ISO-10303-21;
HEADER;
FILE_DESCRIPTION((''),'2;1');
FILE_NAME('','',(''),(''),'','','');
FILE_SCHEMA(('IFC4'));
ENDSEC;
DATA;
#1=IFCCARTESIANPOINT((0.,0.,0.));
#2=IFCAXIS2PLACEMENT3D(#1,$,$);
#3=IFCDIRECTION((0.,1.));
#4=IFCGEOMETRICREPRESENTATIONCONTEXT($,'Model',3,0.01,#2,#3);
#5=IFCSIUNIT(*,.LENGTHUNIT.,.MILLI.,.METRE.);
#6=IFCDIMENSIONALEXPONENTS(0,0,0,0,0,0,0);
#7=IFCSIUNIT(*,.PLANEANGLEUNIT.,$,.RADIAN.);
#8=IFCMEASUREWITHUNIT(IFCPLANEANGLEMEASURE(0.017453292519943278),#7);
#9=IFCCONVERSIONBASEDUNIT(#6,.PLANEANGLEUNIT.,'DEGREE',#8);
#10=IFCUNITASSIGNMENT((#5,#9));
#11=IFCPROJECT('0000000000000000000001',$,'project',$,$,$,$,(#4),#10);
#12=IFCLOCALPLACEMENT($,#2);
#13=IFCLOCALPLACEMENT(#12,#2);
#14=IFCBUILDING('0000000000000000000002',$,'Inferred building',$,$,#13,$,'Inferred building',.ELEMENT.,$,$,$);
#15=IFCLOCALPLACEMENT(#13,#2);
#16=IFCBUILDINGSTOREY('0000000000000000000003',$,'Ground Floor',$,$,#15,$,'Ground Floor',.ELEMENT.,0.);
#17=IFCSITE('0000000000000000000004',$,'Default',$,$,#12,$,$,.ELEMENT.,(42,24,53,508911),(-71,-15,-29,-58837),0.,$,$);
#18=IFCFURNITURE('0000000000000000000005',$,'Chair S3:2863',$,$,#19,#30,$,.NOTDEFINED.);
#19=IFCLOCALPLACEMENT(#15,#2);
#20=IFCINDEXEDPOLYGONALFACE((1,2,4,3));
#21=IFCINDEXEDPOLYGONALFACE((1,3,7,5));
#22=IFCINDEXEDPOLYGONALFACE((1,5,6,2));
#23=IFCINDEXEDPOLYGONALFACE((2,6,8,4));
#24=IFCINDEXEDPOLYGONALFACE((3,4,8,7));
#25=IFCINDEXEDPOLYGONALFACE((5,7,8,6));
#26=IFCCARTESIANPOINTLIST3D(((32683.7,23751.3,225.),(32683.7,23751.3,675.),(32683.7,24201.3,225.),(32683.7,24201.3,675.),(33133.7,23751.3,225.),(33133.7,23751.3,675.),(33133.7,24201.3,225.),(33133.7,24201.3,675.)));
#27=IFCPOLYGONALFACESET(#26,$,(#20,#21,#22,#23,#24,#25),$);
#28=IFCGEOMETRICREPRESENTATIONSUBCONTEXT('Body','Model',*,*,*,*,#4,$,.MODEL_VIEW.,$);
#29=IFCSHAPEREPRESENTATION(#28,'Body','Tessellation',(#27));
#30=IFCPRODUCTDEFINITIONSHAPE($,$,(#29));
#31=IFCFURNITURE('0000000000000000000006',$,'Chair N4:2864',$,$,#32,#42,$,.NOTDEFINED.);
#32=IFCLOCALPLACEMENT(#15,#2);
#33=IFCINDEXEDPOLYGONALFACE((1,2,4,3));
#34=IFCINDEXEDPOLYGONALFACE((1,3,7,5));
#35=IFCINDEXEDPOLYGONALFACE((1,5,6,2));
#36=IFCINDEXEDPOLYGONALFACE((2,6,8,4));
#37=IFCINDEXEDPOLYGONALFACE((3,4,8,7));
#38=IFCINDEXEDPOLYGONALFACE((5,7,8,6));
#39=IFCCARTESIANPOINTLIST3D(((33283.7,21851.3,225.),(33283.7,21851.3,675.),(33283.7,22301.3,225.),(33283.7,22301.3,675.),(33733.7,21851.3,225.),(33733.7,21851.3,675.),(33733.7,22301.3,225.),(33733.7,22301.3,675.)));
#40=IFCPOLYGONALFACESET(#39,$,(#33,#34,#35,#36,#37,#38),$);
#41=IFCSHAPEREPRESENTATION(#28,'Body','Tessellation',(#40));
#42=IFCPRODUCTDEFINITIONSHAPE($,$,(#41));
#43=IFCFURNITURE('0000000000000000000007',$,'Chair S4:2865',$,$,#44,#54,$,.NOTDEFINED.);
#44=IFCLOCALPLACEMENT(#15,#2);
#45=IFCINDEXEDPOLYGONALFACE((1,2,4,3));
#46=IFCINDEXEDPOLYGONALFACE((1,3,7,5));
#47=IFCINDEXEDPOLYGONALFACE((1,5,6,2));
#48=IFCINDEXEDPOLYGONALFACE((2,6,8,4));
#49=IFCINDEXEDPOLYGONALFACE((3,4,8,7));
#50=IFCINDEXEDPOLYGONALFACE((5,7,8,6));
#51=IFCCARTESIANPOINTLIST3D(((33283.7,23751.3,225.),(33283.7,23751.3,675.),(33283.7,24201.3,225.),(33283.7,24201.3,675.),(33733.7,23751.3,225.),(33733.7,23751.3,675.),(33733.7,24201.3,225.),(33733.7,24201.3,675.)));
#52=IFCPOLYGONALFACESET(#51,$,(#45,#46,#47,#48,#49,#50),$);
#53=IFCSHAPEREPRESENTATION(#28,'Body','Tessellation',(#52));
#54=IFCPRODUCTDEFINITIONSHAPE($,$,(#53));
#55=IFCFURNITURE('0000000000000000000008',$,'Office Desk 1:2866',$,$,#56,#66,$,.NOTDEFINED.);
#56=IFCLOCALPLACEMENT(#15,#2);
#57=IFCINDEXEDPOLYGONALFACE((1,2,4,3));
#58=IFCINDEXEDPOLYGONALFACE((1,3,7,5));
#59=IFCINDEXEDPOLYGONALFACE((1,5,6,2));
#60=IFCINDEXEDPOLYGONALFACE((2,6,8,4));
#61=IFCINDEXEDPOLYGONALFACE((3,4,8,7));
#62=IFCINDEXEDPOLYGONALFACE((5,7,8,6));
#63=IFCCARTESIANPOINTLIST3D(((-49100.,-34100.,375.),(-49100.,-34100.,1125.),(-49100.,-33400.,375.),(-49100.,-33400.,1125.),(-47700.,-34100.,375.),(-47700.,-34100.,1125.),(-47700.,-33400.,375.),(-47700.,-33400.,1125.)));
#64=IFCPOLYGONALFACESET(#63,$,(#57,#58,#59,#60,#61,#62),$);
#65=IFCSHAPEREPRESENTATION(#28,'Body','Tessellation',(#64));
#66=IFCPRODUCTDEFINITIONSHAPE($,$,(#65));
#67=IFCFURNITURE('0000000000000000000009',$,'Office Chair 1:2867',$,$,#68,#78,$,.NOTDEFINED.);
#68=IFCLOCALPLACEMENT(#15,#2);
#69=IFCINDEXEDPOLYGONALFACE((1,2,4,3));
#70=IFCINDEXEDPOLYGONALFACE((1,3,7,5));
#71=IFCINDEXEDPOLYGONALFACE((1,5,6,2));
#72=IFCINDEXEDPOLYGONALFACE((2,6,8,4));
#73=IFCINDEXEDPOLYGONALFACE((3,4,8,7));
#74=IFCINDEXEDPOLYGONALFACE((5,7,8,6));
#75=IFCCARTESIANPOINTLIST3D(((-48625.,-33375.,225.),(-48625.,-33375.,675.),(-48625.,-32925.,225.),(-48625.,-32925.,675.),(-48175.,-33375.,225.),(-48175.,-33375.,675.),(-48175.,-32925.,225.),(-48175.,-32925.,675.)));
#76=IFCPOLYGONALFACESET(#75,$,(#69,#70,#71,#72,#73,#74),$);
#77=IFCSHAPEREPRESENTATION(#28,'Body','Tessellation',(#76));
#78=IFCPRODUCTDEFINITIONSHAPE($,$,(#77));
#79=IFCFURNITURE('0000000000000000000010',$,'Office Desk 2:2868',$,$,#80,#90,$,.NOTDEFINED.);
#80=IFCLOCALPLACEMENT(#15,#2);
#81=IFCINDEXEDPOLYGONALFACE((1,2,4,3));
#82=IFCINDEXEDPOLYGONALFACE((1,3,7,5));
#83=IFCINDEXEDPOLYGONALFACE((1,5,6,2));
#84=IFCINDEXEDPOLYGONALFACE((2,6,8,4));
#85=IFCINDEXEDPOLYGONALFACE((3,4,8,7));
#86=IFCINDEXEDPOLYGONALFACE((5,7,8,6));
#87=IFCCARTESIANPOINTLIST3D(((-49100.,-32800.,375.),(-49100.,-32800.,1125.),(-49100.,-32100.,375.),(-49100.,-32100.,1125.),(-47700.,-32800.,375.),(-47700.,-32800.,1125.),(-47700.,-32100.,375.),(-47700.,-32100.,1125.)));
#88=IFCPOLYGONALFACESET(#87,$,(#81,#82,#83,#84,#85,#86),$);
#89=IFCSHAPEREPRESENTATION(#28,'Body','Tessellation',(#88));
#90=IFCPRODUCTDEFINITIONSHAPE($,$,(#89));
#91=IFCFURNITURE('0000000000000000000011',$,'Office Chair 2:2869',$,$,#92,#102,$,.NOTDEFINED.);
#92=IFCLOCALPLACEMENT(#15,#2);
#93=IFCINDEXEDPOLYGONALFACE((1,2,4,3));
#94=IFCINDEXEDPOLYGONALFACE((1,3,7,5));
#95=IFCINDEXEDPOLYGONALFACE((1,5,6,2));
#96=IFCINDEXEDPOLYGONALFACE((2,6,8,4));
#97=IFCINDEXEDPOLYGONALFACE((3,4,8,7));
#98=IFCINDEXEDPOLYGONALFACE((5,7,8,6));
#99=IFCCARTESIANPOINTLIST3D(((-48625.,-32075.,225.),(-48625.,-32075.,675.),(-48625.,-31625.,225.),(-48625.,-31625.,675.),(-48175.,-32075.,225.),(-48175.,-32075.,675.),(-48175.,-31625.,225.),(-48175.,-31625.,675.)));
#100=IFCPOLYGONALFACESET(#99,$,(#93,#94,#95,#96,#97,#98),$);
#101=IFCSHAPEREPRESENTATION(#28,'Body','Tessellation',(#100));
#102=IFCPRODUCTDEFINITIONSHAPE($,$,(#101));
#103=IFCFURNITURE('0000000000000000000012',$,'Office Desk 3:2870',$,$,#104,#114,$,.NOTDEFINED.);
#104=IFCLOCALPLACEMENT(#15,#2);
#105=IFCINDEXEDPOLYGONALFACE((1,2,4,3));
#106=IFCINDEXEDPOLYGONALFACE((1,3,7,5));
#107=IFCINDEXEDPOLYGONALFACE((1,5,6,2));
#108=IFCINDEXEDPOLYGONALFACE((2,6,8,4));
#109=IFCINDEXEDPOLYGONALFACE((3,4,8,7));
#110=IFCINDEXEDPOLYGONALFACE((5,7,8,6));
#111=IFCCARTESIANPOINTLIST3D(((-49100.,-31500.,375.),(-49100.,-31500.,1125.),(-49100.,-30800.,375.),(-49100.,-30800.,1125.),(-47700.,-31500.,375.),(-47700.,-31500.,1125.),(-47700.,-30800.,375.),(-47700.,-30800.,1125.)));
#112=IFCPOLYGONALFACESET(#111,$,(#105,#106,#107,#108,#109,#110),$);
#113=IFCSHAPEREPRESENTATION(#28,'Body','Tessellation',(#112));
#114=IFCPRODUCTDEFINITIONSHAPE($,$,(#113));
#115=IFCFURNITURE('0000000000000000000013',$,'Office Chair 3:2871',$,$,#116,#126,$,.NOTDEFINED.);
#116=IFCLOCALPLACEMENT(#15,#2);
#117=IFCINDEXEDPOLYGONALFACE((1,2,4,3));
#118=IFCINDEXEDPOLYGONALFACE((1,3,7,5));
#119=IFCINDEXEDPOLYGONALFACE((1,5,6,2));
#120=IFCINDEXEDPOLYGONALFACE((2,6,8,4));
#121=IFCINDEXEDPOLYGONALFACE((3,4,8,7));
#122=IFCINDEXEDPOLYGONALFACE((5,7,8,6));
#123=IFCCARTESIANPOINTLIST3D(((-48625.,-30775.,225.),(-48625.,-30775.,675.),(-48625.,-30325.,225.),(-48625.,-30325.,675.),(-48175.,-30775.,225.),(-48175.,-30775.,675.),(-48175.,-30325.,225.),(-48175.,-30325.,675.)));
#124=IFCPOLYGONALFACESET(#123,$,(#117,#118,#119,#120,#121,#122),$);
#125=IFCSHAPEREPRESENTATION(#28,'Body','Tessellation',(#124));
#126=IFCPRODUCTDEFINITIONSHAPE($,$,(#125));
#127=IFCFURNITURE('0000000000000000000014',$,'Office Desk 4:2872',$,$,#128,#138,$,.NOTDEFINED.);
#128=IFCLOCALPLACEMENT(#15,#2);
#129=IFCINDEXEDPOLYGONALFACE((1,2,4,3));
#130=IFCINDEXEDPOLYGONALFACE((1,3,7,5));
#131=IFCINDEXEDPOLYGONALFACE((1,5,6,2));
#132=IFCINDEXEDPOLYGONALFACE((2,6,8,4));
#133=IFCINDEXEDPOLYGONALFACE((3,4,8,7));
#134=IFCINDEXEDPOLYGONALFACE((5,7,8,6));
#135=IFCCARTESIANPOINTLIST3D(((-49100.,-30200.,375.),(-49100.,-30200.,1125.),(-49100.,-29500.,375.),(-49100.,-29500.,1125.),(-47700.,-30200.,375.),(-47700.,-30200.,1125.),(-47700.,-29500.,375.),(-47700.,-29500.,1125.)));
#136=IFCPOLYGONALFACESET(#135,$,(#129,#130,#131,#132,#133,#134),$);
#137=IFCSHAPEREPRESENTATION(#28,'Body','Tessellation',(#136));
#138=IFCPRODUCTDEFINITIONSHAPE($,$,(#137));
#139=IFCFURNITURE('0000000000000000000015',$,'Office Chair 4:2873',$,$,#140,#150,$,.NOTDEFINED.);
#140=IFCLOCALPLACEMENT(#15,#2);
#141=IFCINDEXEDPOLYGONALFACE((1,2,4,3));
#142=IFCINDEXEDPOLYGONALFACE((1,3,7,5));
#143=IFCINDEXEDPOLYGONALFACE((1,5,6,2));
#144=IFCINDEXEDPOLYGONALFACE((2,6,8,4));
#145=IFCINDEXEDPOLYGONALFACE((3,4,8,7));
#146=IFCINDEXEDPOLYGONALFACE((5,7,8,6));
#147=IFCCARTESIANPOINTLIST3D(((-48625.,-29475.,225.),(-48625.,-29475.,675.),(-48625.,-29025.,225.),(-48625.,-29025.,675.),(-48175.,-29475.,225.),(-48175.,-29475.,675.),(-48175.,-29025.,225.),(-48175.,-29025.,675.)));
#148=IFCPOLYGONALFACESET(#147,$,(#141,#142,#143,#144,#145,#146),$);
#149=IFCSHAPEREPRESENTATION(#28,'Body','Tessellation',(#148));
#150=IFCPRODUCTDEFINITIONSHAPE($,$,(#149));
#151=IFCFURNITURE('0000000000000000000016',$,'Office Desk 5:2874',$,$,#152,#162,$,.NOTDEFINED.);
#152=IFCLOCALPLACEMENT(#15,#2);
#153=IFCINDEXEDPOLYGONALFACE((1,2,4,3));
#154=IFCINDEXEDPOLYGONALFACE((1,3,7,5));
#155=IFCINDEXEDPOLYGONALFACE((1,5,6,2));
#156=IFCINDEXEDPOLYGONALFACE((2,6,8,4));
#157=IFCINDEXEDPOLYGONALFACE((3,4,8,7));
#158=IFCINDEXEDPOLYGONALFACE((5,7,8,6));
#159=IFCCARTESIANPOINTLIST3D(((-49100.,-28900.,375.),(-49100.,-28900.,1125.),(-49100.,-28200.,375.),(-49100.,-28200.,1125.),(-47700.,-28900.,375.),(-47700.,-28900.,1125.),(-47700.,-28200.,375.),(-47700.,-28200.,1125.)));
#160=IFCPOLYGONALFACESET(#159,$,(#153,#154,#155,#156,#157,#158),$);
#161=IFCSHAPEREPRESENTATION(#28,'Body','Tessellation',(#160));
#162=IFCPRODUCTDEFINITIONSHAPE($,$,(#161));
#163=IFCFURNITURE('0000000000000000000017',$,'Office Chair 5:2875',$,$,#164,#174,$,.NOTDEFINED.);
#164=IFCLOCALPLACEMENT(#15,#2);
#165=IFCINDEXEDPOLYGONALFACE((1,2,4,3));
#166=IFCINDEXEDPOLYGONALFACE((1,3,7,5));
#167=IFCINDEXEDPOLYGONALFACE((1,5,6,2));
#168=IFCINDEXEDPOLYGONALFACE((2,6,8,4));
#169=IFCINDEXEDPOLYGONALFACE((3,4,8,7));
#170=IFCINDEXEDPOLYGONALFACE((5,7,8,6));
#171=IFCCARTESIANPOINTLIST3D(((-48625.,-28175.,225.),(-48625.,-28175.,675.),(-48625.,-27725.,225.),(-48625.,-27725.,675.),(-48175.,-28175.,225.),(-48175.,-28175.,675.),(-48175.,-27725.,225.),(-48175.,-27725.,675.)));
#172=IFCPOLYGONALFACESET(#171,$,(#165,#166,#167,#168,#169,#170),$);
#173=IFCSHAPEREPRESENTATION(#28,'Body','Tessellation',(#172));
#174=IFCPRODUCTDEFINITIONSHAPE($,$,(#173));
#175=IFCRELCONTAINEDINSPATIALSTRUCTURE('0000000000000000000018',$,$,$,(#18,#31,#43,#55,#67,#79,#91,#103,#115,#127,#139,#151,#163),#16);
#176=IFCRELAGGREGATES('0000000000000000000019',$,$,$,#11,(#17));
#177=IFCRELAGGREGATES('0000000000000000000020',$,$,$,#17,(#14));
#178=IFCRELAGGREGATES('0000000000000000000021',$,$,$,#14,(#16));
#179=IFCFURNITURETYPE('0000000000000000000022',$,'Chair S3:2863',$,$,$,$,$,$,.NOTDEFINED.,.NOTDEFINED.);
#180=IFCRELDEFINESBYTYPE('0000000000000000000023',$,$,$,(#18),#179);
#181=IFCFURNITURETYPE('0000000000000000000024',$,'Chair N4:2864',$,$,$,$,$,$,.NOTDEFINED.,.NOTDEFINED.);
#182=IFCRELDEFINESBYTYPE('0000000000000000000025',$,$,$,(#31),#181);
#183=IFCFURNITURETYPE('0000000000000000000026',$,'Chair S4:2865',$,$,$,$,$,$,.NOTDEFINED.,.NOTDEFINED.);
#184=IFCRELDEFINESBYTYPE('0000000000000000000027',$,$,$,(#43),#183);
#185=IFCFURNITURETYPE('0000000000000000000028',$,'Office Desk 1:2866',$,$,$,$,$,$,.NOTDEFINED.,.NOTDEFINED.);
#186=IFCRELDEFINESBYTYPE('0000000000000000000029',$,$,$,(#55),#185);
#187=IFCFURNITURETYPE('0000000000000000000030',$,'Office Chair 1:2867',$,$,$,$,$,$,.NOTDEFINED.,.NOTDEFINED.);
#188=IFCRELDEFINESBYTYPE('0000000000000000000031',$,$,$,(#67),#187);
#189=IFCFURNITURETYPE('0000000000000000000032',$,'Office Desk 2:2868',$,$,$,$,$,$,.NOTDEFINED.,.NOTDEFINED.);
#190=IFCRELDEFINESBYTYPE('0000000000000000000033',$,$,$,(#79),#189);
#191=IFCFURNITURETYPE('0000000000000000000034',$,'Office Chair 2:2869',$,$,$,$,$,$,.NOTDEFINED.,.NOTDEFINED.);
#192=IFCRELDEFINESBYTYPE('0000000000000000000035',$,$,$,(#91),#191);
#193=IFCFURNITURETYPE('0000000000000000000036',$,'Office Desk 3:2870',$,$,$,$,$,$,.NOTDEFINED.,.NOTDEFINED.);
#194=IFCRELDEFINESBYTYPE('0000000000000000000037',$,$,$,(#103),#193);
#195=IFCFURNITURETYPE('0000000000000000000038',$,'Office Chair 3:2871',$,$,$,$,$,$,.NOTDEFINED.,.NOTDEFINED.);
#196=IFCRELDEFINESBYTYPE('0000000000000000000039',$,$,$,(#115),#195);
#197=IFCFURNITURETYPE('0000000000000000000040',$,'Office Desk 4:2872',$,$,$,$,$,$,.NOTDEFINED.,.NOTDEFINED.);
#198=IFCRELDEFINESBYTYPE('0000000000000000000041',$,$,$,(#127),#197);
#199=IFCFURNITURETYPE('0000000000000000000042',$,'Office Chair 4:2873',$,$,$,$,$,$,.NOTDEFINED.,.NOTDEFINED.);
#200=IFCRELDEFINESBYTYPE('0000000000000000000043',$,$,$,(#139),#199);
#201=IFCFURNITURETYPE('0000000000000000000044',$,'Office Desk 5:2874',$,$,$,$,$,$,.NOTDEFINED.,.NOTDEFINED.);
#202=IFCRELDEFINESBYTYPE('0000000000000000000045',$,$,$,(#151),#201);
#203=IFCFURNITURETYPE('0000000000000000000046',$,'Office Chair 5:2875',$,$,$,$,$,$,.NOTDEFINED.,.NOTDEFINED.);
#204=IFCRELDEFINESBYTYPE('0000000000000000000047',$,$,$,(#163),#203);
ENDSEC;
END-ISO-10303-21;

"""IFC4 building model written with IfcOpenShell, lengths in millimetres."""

from ifc_helpers import new_model, entity, si_unit, converted_unit, direction, frame, origin, origin_2d_with_axis, place, context, subcontext, project, spatial, rectangle, extrude, type_object, element, save


model = new_model("IFC4")

# Units and contexts
model_context = context("Model", 3, precision=0.01, world=origin(), true_north=direction((0.0, 1.0)))
body_context = subcontext(model_context, "Body", "Model", "MODEL_VIEW")
ifc_project = project(units=[si_unit("LENGTHUNIT", "METRE", prefix="MILLI"), converted_unit("PLANEANGLEUNIT", "DEGREE", entity("IfcPlaneAngleMeasure", 0.017453292519943278), si_unit("PLANEANGLEUNIT", "RADIAN"), dimensions=[0, 0, 0, 0, 0, 0, 0])], contexts=[model_context])

# Site, building, storey
site_placement = place(None, origin())
site = spatial("IfcSite", under=ifc_project, at=site_placement, Name="Default", CompositionType="ELEMENT", RefLatitude=(42, 24, 53, 508911), RefLongitude=(-71, -15, -29, -58837), RefElevation=0.0)
building_placement = place(site_placement, origin())
building = spatial("IfcBuilding", under=site, at=building_placement, Name="Inferred building", LongName="Inferred building", CompositionType="ELEMENT")
storey_placement = place(building_placement, origin())
storey = spatial("IfcBuildingStorey", under=building, at=storey_placement, Name="Ground Floor", LongName="Ground Floor", CompositionType="ELEMENT", Elevation=0.0)

# Furniture
furniture_type_1 = type_object("IfcFurnitureType", Name="Chair S3:2863", PredefinedType="NOTDEFINED")
furniture_1_placement = place(storey_placement, origin())
element("IfcFurniture", 1, at=furniture_1_placement, inside=storey, type_object=furniture_type_1, Name="Chair S3:2863", PredefinedType="NOTDEFINED", context=body_context, shape_type="SweptSolid", body=[
    extrude(rectangle(XDim=450.0, YDim=450.0, at=origin_2d_with_axis()), frame((32908.7, 23976.3, 225.0)), (0.0, 0.0, 1.0), 450.0),
])
furniture_type_2 = type_object("IfcFurnitureType", Name="Chair N4:2864", PredefinedType="NOTDEFINED")
furniture_2_placement = place(storey_placement, origin())
element("IfcFurniture", 2, at=furniture_2_placement, inside=storey, type_object=furniture_type_2, Name="Chair N4:2864", PredefinedType="NOTDEFINED", context=body_context, shape_type="SweptSolid", body=[
    extrude(rectangle(XDim=450.0, YDim=450.0, at=origin_2d_with_axis()), frame((33508.7, 22076.3, 225.0)), (0.0, 0.0, 1.0), 450.0),
])
furniture_type_3 = type_object("IfcFurnitureType", Name="Chair S4:2865", PredefinedType="NOTDEFINED")
furniture_3_placement = place(storey_placement, origin())
element("IfcFurniture", 3, at=furniture_3_placement, inside=storey, type_object=furniture_type_3, Name="Chair S4:2865", PredefinedType="NOTDEFINED", context=body_context, shape_type="SweptSolid", body=[
    extrude(rectangle(XDim=450.0, YDim=450.0, at=origin_2d_with_axis()), frame((33508.7, 23976.3, 225.0)), (0.0, 0.0, 1.0), 450.0),
])
furniture_type_4 = type_object("IfcFurnitureType", Name="Office Desk 1:2866", PredefinedType="NOTDEFINED")
furniture_4_placement = place(storey_placement, origin())
element("IfcFurniture", 4, at=furniture_4_placement, inside=storey, type_object=furniture_type_4, Name="Office Desk 1:2866", PredefinedType="NOTDEFINED", context=body_context, shape_type="SweptSolid", body=[
    extrude(rectangle(XDim=1400.0, YDim=700.0, at=origin_2d_with_axis()), frame((-48400.0, -33750.0, 375.0)), (0.0, 0.0, 1.0), 750.0),
])
furniture_type_5 = type_object("IfcFurnitureType", Name="Office Chair 1:2867", PredefinedType="NOTDEFINED")
furniture_5_placement = place(storey_placement, origin())
element("IfcFurniture", 5, at=furniture_5_placement, inside=storey, type_object=furniture_type_5, Name="Office Chair 1:2867", PredefinedType="NOTDEFINED", context=body_context, shape_type="SweptSolid", body=[
    extrude(rectangle(XDim=450.0, YDim=450.0, at=origin_2d_with_axis()), frame((-48400.0, -33150.0, 225.0)), (0.0, 0.0, 1.0), 450.0),
])
furniture_type_6 = type_object("IfcFurnitureType", Name="Office Desk 2:2868", PredefinedType="NOTDEFINED")
furniture_6_placement = place(storey_placement, origin())
element("IfcFurniture", 6, at=furniture_6_placement, inside=storey, type_object=furniture_type_6, Name="Office Desk 2:2868", PredefinedType="NOTDEFINED", context=body_context, shape_type="SweptSolid", body=[
    extrude(rectangle(XDim=1400.0, YDim=700.0, at=origin_2d_with_axis()), frame((-48400.0, -32450.0, 375.0)), (0.0, 0.0, 1.0), 750.0),
])
furniture_type_7 = type_object("IfcFurnitureType", Name="Office Chair 2:2869", PredefinedType="NOTDEFINED")
furniture_7_placement = place(storey_placement, origin())
element("IfcFurniture", 7, at=furniture_7_placement, inside=storey, type_object=furniture_type_7, Name="Office Chair 2:2869", PredefinedType="NOTDEFINED", context=body_context, shape_type="SweptSolid", body=[
    extrude(rectangle(XDim=450.0, YDim=450.0, at=origin_2d_with_axis()), frame((-48400.0, -31850.0, 225.0)), (0.0, 0.0, 1.0), 450.0),
])
furniture_type_8 = type_object("IfcFurnitureType", Name="Office Desk 3:2870", PredefinedType="NOTDEFINED")
furniture_8_placement = place(storey_placement, origin())
element("IfcFurniture", 8, at=furniture_8_placement, inside=storey, type_object=furniture_type_8, Name="Office Desk 3:2870", PredefinedType="NOTDEFINED", context=body_context, shape_type="SweptSolid", body=[
    extrude(rectangle(XDim=1400.0, YDim=700.0, at=origin_2d_with_axis()), frame((-48400.0, -31150.0, 375.0)), (0.0, 0.0, 1.0), 750.0),
])
furniture_type_9 = type_object("IfcFurnitureType", Name="Office Chair 3:2871", PredefinedType="NOTDEFINED")
furniture_9_placement = place(storey_placement, origin())
element("IfcFurniture", 9, at=furniture_9_placement, inside=storey, type_object=furniture_type_9, Name="Office Chair 3:2871", PredefinedType="NOTDEFINED", context=body_context, shape_type="SweptSolid", body=[
    extrude(rectangle(XDim=450.0, YDim=450.0, at=origin_2d_with_axis()), frame((-48400.0, -30550.0, 225.0)), (0.0, 0.0, 1.0), 450.0),
])
furniture_type_10 = type_object("IfcFurnitureType", Name="Office Desk 4:2872", PredefinedType="NOTDEFINED")
furniture_10_placement = place(storey_placement, origin())
element("IfcFurniture", 10, at=furniture_10_placement, inside=storey, type_object=furniture_type_10, Name="Office Desk 4:2872", PredefinedType="NOTDEFINED", context=body_context, shape_type="SweptSolid", body=[
    extrude(rectangle(XDim=1400.0, YDim=700.0, at=origin_2d_with_axis()), frame((-48400.0, -29850.0, 375.0)), (0.0, 0.0, 1.0), 750.0),
])
furniture_type_11 = type_object("IfcFurnitureType", Name="Office Chair 4:2873", PredefinedType="NOTDEFINED")
furniture_11_placement = place(storey_placement, origin())
element("IfcFurniture", 11, at=furniture_11_placement, inside=storey, type_object=furniture_type_11, Name="Office Chair 4:2873", PredefinedType="NOTDEFINED", context=body_context, shape_type="SweptSolid", body=[
    extrude(rectangle(XDim=450.0, YDim=450.0, at=origin_2d_with_axis()), frame((-48400.0, -29250.0, 225.0)), (0.0, 0.0, 1.0), 450.0),
])
furniture_type_12 = type_object("IfcFurnitureType", Name="Office Desk 5:2874", PredefinedType="NOTDEFINED")
furniture_12_placement = place(storey_placement, origin())
element("IfcFurniture", 12, at=furniture_12_placement, inside=storey, type_object=furniture_type_12, Name="Office Desk 5:2874", PredefinedType="NOTDEFINED", context=body_context, shape_type="SweptSolid", body=[
    extrude(rectangle(XDim=1400.0, YDim=700.0, at=origin_2d_with_axis()), frame((-48400.0, -28550.0, 375.0)), (0.0, 0.0, 1.0), 750.0),
])
furniture_type_13 = type_object("IfcFurnitureType", Name="Office Chair 5:2875", PredefinedType="NOTDEFINED")
furniture_13_placement = place(storey_placement, origin())
element("IfcFurniture", 13, at=furniture_13_placement, inside=storey, type_object=furniture_type_13, Name="Office Chair 5:2875", PredefinedType="NOTDEFINED", context=body_context, shape_type="SweptSolid", body=[
    extrude(rectangle(XDim=450.0, YDim=450.0, at=origin_2d_with_axis()), frame((-48400.0, -27950.0, 225.0)), (0.0, 0.0, 1.0), 450.0),
])

save(model, "model.ifc")
